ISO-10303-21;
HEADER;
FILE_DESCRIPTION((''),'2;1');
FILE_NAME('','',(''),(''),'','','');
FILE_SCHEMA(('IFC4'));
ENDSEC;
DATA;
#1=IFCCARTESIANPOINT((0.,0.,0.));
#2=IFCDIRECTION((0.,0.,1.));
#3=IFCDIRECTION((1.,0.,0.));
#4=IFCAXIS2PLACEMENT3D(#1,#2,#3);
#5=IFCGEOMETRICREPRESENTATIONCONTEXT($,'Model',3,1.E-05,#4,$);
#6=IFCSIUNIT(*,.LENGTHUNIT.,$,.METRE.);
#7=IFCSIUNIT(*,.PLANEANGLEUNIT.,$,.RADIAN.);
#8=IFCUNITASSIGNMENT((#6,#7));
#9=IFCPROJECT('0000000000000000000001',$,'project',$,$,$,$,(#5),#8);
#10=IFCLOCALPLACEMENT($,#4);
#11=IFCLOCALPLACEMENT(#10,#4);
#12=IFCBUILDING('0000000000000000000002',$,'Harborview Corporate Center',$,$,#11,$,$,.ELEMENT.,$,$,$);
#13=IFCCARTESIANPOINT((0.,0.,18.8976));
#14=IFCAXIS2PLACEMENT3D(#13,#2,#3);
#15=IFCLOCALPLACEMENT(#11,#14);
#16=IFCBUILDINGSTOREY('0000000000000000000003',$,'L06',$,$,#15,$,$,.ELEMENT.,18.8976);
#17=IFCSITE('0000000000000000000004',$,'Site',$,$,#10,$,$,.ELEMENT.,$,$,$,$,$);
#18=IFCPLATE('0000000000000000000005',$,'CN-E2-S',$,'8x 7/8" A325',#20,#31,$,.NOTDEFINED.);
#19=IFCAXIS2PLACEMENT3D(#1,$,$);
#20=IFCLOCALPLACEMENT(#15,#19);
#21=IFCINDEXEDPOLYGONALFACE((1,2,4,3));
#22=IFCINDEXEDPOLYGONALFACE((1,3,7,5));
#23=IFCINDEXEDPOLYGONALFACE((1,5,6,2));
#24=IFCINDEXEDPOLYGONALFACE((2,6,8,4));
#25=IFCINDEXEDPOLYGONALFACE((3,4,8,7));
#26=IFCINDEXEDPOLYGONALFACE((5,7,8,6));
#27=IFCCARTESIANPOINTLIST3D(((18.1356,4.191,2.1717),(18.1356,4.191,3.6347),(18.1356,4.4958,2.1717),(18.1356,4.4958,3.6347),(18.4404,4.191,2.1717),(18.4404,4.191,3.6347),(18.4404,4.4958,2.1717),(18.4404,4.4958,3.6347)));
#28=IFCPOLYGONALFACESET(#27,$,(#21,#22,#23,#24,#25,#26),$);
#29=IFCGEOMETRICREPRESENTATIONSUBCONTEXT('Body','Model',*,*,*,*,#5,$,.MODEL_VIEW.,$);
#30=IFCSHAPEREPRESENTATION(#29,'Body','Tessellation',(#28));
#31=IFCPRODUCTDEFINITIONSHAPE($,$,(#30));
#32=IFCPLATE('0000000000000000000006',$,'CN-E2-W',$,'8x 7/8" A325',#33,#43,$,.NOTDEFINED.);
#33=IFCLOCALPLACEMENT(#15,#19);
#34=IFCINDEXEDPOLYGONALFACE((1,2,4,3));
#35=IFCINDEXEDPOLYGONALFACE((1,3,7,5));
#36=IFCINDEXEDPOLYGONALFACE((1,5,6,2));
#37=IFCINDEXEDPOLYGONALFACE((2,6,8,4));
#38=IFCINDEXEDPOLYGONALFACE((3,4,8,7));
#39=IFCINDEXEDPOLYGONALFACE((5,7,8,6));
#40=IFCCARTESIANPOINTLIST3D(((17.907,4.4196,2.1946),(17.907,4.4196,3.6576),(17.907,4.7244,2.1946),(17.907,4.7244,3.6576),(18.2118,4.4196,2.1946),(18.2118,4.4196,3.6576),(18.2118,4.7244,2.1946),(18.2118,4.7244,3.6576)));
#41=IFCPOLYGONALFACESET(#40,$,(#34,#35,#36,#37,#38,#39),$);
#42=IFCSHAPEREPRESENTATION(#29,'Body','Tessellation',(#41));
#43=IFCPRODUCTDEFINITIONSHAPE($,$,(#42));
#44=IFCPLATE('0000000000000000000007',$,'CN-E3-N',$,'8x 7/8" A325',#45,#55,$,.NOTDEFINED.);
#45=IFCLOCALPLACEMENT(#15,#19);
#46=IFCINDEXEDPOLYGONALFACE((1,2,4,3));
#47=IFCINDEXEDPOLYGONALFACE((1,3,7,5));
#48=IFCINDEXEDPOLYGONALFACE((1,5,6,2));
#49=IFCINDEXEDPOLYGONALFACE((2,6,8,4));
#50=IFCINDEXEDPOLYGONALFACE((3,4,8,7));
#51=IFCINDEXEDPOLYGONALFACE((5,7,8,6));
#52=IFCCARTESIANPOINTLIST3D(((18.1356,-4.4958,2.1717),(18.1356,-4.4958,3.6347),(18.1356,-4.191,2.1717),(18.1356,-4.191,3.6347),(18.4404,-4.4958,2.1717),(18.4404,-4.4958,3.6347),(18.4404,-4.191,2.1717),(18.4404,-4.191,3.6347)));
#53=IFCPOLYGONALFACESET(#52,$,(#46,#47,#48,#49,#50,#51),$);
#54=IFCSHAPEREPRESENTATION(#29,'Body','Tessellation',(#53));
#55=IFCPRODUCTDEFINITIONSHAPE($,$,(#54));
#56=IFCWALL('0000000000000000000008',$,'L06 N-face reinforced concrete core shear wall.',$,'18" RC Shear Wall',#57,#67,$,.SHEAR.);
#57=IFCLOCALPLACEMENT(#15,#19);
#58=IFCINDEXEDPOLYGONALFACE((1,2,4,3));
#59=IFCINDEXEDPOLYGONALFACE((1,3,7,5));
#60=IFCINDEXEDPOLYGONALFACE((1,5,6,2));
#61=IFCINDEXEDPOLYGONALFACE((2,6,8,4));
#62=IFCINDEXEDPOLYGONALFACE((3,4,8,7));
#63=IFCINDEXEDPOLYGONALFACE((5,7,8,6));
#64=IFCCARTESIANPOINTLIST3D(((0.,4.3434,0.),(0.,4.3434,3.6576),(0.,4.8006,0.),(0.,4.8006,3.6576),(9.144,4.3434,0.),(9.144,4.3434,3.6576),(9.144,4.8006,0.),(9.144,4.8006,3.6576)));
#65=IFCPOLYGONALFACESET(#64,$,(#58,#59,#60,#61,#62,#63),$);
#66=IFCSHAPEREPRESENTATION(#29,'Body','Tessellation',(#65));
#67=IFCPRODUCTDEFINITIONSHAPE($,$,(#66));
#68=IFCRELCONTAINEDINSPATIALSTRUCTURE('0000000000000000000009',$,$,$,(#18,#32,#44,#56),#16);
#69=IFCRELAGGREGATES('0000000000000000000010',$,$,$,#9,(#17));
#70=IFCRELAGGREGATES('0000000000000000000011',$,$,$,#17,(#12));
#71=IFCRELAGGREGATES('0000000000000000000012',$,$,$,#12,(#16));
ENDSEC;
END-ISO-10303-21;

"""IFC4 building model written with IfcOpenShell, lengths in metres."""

from ifc_helpers import new_model, si_unit, frame, origin_with_axes, place, context, subcontext, project, spatial, rectangle, extrude, element, save


model = new_model("IFC4")

# Units and contexts
model_context = context("Model", 3, precision=1e-05, world=origin_with_axes())
body_context = subcontext(model_context, "Body", "Model", "MODEL_VIEW")
ifc_project = project(units=[si_unit("LENGTHUNIT", "METRE"), si_unit("PLANEANGLEUNIT", "RADIAN")], contexts=[model_context])

# Site, building, storey
site_placement = place(None, origin_with_axes())
site = spatial("IfcSite", under=ifc_project, at=site_placement, Name="Site", CompositionType="ELEMENT")
building_placement = place(site_placement, origin_with_axes())
building = spatial("IfcBuilding", under=site, at=building_placement, Name="Harborview Corporate Center", CompositionType="ELEMENT")
storey_placement = place(building_placement, frame((0.0, 0.0, 18.8976), z_axis=(0.0, 0.0, 1.0), x_axis=(1.0, 0.0, 0.0)))
storey = spatial("IfcBuildingStorey", under=building, at=storey_placement, Name="L06", CompositionType="ELEMENT", Elevation=18.8976)

# Plates
for number, where, z_axis, x_axis, name in (
    (1, (18.288, 4.3434, 2.1717), (0.0, 0.0, 1.0), (1.0, 0.0, 0.0), "CN-E2-S"),
    (2, (18.0594, 4.572, 2.1946), (0.0, 0.0, 1.0), (1.0, 0.0, 0.0), "CN-E2-W"),
    (3, (18.288, -4.3434, 2.1717), (0.0, 0.0, 1.0), (1.0, 0.0, 0.0), "CN-E3-N"),
):
    element("IfcPlate", number, at=place(storey_placement, frame(where, z_axis=z_axis, x_axis=x_axis)), inside=storey, Name=name, ObjectType="8x 7/8\" A325", PredefinedType="NOTDEFINED", context=body_context, shape_type="SweptSolid", body=[
        extrude(rectangle(XDim=0.3048, YDim=0.3048), origin_with_axes(), (0.0, 0.0, 1.0), 1.463),
    ])

# Wall
wall_placement = place(storey_placement, frame((4.572, 4.572, 0.0), z_axis=(0.0, 0.0, 1.0), x_axis=(1.0, 0.0, 0.0)))
element("IfcWall", 4, at=wall_placement, inside=storey, Name="L06 N-face reinforced concrete core shear wall.", ObjectType="18\" RC Shear Wall", PredefinedType="SHEAR", context=body_context, shape_type="SweptSolid", body=[
    extrude(rectangle(XDim=9.144, YDim=0.4572), origin_with_axes(), (0.0, 0.0, 1.0), 3.6576),
])

save(model, "model.ifc")
